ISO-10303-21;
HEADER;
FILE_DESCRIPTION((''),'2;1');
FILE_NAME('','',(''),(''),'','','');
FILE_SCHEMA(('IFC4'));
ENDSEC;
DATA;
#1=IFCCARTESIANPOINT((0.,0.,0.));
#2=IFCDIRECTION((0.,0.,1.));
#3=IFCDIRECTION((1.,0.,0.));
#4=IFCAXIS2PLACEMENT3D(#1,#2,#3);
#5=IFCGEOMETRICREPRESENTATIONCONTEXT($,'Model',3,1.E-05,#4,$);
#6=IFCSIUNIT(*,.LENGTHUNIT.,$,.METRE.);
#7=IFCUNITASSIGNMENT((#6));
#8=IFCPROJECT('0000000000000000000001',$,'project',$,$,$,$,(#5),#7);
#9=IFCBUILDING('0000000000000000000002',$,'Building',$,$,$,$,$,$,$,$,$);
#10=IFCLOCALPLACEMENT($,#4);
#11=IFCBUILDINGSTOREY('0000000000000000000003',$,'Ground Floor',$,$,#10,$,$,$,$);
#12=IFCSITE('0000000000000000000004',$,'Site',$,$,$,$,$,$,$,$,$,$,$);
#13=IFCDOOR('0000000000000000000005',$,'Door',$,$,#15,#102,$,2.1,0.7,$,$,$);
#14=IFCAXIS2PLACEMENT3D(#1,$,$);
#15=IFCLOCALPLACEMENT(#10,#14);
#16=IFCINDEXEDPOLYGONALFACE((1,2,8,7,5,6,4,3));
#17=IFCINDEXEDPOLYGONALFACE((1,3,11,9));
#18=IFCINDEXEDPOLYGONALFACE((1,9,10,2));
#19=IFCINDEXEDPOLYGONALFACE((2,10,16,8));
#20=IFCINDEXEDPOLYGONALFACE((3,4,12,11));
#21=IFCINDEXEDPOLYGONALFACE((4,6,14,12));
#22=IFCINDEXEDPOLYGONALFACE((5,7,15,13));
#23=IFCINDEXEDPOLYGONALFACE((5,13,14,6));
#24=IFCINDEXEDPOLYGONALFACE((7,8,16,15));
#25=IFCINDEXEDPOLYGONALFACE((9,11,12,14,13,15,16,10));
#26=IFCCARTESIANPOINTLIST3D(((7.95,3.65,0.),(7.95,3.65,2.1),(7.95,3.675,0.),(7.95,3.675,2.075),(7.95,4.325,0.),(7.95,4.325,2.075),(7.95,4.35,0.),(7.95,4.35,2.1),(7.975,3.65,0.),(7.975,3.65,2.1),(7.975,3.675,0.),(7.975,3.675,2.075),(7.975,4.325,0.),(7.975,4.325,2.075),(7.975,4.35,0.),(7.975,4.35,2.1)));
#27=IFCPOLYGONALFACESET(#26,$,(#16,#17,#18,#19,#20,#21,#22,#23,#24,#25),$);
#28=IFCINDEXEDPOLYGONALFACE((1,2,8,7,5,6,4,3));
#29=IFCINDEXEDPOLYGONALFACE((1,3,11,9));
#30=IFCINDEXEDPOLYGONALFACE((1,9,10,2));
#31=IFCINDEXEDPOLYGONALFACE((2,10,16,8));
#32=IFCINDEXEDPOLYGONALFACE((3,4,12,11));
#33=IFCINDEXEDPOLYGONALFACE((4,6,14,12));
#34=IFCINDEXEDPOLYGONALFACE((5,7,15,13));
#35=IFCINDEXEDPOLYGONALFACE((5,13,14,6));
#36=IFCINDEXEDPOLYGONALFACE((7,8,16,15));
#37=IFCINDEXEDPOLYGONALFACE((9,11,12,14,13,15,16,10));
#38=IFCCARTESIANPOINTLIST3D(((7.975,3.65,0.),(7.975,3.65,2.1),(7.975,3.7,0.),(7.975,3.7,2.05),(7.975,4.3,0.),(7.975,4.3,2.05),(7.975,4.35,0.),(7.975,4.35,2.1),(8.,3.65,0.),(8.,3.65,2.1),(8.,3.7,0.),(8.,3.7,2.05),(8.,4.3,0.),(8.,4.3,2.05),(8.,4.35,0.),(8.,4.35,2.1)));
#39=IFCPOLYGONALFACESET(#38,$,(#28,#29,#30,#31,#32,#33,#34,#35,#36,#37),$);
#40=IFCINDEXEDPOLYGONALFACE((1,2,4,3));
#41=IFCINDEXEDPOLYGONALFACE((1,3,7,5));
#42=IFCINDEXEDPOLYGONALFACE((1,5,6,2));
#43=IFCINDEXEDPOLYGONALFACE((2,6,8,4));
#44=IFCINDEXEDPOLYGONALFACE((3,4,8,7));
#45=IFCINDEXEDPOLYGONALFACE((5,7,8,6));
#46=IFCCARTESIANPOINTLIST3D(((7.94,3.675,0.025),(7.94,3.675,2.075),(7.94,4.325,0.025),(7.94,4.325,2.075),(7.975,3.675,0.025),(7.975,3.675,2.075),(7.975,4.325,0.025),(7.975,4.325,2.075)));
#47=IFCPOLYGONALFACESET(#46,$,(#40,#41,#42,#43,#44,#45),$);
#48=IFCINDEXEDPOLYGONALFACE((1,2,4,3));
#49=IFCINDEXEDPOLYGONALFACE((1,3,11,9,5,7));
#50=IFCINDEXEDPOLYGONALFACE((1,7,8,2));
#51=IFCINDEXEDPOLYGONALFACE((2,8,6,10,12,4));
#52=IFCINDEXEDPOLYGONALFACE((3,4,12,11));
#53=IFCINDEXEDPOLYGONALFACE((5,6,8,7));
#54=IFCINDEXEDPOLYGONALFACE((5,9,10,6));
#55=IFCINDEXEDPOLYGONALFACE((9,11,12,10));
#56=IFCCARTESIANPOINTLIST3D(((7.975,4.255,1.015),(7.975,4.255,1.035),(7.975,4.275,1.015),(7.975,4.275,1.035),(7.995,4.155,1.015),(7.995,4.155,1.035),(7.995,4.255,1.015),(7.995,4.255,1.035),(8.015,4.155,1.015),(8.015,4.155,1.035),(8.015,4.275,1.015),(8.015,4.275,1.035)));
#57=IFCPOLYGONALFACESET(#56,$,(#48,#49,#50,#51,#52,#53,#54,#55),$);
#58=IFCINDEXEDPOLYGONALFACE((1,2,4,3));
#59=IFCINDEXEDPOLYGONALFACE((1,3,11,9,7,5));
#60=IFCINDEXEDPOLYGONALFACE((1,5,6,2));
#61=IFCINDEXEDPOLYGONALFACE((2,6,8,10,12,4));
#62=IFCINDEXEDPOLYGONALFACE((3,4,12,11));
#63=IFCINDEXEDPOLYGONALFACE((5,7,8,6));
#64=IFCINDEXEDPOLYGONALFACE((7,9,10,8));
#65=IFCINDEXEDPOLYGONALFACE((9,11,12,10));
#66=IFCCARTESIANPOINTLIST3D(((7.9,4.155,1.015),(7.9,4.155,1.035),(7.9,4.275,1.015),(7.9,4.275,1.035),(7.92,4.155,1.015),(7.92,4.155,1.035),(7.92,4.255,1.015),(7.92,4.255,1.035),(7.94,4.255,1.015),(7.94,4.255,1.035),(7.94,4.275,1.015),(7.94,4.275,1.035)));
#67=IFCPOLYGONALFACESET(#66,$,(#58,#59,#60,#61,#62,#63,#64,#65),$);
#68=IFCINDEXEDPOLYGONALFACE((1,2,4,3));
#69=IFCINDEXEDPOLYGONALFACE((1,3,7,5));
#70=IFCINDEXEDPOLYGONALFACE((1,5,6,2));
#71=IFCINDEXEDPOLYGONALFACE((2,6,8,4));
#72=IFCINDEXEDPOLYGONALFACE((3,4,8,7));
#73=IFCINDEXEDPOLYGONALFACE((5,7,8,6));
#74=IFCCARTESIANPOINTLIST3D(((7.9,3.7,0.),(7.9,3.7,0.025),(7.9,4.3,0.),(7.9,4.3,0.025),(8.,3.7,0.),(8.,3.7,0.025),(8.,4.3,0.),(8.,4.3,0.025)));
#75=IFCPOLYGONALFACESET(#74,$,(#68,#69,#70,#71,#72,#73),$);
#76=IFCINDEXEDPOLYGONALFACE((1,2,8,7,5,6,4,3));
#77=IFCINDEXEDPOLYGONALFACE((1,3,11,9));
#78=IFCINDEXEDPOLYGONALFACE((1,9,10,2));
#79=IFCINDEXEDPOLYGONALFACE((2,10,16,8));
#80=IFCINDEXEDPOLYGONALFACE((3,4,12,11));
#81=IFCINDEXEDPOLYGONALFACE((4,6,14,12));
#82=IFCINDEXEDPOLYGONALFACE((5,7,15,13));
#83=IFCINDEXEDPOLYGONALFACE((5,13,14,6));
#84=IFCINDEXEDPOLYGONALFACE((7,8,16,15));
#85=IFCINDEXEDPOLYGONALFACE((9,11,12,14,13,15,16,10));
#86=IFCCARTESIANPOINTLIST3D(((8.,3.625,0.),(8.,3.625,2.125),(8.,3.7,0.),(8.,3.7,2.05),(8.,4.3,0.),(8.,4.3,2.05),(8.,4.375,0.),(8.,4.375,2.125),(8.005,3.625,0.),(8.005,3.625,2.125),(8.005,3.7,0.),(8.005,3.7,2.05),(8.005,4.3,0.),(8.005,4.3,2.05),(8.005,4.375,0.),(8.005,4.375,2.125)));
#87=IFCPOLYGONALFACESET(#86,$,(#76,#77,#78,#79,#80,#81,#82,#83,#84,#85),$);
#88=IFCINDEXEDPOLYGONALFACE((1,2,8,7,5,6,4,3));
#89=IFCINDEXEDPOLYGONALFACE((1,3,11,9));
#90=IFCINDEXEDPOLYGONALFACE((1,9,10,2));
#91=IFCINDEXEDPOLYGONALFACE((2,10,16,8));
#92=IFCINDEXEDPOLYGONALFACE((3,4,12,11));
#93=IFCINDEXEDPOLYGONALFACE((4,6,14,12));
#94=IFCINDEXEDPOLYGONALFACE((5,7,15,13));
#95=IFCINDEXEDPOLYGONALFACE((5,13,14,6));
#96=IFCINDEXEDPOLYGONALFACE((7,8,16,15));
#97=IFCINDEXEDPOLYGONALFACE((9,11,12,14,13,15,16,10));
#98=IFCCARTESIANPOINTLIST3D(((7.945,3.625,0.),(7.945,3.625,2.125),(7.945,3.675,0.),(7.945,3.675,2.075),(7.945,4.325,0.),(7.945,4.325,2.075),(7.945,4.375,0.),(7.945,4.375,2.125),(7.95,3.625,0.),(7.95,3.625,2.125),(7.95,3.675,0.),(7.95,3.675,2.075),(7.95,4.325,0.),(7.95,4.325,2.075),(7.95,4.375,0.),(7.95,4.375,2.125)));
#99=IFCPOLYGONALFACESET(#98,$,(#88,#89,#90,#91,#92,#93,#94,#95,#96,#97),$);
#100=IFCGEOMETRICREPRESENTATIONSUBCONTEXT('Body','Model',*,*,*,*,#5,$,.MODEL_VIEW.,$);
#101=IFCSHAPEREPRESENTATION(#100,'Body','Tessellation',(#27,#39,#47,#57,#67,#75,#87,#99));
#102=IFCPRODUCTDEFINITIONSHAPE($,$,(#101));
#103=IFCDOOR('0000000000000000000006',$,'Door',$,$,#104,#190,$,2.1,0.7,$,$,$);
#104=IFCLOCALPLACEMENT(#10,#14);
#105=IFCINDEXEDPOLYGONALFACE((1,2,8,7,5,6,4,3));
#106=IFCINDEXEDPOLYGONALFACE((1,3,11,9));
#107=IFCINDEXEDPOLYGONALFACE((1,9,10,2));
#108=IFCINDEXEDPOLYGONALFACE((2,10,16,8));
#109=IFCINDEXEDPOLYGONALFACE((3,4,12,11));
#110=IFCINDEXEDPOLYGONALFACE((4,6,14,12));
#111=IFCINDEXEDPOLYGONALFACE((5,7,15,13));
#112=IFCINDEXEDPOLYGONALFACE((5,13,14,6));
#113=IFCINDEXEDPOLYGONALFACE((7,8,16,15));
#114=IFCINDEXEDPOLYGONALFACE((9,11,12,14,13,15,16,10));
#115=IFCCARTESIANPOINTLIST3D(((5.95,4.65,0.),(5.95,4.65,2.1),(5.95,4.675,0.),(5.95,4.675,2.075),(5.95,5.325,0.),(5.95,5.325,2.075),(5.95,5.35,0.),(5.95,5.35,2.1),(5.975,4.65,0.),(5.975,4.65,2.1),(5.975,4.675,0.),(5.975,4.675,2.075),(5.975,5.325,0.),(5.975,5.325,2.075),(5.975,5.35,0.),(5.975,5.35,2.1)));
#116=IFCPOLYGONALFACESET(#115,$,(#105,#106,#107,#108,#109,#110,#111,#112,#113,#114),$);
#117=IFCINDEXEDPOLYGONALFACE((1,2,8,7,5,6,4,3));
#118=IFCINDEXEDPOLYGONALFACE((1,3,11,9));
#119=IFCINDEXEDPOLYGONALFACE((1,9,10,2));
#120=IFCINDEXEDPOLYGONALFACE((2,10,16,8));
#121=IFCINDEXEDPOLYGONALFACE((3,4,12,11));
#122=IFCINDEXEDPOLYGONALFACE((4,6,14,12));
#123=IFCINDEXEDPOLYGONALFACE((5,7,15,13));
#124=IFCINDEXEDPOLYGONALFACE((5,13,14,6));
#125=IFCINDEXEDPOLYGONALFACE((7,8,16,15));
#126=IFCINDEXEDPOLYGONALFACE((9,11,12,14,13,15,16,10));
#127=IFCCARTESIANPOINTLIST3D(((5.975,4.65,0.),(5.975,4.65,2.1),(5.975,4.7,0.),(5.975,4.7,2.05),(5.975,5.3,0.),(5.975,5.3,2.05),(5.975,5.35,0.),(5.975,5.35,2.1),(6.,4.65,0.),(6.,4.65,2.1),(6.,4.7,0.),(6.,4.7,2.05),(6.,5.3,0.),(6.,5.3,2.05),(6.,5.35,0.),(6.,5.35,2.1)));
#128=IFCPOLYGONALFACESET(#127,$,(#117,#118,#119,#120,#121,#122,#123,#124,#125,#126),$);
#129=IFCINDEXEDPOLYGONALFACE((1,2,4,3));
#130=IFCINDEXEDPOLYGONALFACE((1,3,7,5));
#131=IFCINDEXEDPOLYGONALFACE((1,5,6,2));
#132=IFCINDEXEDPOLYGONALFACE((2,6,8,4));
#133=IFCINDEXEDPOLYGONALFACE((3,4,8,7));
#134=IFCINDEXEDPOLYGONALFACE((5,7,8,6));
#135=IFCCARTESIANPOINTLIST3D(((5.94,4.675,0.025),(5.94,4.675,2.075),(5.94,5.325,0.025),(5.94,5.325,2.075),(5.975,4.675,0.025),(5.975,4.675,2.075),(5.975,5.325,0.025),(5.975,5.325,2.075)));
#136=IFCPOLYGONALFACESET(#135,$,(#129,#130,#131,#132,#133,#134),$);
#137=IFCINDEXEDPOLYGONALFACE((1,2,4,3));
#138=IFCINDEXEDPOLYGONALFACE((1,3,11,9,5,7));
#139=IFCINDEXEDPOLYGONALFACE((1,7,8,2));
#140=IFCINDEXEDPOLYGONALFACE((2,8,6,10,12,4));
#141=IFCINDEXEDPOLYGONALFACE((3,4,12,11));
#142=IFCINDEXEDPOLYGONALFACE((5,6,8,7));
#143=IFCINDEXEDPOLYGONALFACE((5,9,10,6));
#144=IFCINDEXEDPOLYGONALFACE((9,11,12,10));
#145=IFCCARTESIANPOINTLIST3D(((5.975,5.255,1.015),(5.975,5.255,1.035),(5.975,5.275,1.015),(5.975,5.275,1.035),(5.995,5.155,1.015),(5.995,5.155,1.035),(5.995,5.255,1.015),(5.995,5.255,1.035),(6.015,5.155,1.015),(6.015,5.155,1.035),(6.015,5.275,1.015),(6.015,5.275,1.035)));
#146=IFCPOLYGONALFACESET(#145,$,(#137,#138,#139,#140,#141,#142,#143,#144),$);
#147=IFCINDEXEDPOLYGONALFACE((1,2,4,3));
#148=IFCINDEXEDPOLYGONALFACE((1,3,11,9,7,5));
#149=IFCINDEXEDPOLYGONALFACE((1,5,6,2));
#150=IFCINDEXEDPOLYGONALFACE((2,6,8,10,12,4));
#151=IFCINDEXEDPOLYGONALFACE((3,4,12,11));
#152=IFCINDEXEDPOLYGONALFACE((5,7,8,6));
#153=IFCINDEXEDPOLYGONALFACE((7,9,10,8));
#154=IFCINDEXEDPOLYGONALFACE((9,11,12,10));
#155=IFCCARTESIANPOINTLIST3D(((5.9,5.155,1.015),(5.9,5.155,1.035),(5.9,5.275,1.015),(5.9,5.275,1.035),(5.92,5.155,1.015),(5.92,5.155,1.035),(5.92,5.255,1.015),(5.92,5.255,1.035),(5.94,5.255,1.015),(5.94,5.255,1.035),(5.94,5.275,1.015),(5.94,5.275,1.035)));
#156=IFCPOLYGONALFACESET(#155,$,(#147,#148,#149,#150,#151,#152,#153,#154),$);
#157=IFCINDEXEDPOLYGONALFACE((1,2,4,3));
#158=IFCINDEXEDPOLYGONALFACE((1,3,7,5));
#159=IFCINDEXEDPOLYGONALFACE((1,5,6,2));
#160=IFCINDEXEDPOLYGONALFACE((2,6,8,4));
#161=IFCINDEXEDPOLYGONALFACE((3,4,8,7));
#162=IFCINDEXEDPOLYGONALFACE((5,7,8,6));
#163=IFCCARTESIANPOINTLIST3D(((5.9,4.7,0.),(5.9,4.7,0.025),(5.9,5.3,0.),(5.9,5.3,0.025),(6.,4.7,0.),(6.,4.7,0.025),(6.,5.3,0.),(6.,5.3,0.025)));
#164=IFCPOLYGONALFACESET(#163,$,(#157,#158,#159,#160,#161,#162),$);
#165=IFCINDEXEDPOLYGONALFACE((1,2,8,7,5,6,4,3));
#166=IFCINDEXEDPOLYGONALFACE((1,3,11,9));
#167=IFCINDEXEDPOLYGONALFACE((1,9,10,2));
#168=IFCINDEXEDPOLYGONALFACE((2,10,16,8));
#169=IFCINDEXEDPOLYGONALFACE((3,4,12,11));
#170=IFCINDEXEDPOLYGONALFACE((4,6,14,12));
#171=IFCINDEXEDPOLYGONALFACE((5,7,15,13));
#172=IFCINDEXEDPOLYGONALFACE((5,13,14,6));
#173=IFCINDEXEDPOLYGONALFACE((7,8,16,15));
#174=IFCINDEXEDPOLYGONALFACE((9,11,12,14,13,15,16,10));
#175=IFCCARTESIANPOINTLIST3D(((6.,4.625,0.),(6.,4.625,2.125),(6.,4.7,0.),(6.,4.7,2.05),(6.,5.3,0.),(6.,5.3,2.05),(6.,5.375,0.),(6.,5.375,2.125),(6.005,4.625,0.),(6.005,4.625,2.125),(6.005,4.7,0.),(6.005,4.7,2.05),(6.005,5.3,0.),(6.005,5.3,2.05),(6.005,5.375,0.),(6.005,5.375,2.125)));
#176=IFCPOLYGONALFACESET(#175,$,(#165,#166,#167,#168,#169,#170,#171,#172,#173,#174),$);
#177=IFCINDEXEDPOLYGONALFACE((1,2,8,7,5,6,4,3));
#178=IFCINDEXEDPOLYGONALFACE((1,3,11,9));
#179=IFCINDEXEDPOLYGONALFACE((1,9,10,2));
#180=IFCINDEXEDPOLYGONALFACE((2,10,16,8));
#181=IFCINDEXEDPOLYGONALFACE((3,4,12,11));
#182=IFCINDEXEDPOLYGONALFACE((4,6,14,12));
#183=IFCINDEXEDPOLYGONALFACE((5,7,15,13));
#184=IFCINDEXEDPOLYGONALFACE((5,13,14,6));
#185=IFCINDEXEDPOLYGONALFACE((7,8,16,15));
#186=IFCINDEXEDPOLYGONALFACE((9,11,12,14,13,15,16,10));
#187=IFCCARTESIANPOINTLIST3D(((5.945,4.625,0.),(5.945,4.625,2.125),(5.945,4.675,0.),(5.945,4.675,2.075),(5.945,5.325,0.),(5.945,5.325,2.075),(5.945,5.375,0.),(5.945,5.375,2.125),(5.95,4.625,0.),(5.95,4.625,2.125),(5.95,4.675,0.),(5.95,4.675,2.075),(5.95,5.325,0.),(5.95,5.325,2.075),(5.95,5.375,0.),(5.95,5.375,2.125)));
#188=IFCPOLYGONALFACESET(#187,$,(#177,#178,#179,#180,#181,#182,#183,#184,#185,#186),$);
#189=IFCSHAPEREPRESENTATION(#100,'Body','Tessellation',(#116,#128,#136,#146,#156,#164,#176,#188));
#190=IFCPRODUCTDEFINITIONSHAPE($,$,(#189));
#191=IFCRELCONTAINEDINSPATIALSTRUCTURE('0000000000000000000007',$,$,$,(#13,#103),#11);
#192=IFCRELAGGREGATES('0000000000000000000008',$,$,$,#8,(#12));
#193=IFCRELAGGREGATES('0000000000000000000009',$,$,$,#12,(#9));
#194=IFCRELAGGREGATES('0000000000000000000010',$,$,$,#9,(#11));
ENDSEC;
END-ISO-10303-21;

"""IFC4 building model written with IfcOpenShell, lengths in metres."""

from ifc_helpers import new_model, si_unit, frame, origin_with_axes, place, context, subcontext, project, spatial, line, indexed_curve, outline, extrude, element, save


model = new_model("IFC4")

# Units and contexts
model_context = context("Model", 3, precision=1e-05, world=origin_with_axes())
body_context = subcontext(model_context, "Body", "Model", "MODEL_VIEW")
ifc_project = project(units=[si_unit("LENGTHUNIT", "METRE")], contexts=[model_context])

# Site, building, storey
site = spatial("IfcSite", under=ifc_project, Name="Site")
building = spatial("IfcBuilding", under=site, Name="Building")
storey_placement = place(None, origin_with_axes())
storey = spatial("IfcBuildingStorey", under=building, at=storey_placement, Name="Ground Floor")

# Doors
door_1_placement = place(storey_placement, frame((8.0, 3.65, 0.0), z_axis=(0.0, 0.0, 1.0), x_axis=(0.0, 1.0, 0.0)))
element("IfcDoor", 1, at=door_1_placement, inside=storey, Name="Door", OverallHeight=2.1, OverallWidth=0.7, context=body_context, shape_type="SweptSolid", body=[
    extrude(outline(indexed_curve([(0.0, 0.0), (0.0, 2.1), (0.7, 2.1), (0.7, 0.0), (0.675, 0.0), (0.675, 2.075), (0.025, 2.075), (0.025, 0.0)], segments=[line(1, 2, 3, 4, 5, 6, 7, 8, 1)])), frame((0.0, 0.025, 0.0), z_axis=(0.0, -1.0, 0.0), x_axis=(1.0, 0.0, 0.0)), (0.0, 0.0, -1.0), 0.025),
    extrude(outline(indexed_curve([(0.0, 0.0), (0.0, 2.1), (0.7, 2.1), (0.7, 0.0), (0.65, 0.0), (0.65, 2.05), (0.05, 2.05), (0.05, 0.0)], segments=[line(1, 2, 3, 4, 5, 6, 7, 8, 1)])), frame((0.0, 0.0, 0.0), z_axis=(0.0, -1.0, 0.0), x_axis=(1.0, 0.0, 0.0)), (0.0, 0.0, -1.0), 0.025),
    extrude(outline(indexed_curve([(0.0, 0.0), (0.65, 0.0), (0.65, 0.035), (0.0, 0.035)], segments=[line(1, 2, 3, 4, 1)])), frame((0.025, 0.025, 0.025), z_axis=(0.0, 0.0, 1.0), x_axis=(1.0, 0.0, 0.0)), (0.0, 0.0, 1.0), 2.05),
    extrude(outline(indexed_curve([(0.0, 0.0), (0.0, -0.04), (-0.12, -0.04), (-0.12, -0.02), (-0.02, -0.02), (-0.02, 0.0)], segments=[line(1, 2, 3, 4, 5, 6, 1)])), frame((0.625, 0.025, 1.015), z_axis=(0.0, 0.0, 1.0), x_axis=(1.0, 0.0, 0.0)), (0.0, 0.0, 1.0), 0.02),
    extrude(outline(indexed_curve([(0.0, 0.0), (0.0, 0.04), (-0.12, 0.04), (-0.12, 0.02), (-0.02, 0.02), (-0.02, 0.0)], segments=[line(1, 2, 3, 4, 5, 6, 1)])), frame((0.625, 0.06, 1.015), z_axis=(0.0, 0.0, 1.0), x_axis=(1.0, 0.0, 0.0)), (0.0, 0.0, 1.0), 0.02),
    extrude(outline(indexed_curve([(0.0, 0.0), (0.6, 0.0), (0.6, 0.1), (0.0, 0.1)], segments=[line(1, 2, 3, 4, 1)])), frame((0.05, 0.0, 0.0), z_axis=(0.0, 0.0, 1.0), x_axis=(1.0, 0.0, 0.0)), (0.0, 0.0, 1.0), 0.025),
    extrude(outline(indexed_curve([(0.0, 0.0), (0.0, 2.125), (0.75, 2.125), (0.75, 0.0), (0.675, 0.0), (0.675, 2.05), (0.075, 2.05), (0.075, 0.0)], segments=[line(1, 2, 3, 4, 5, 6, 7, 8, 1)])), frame((-0.025, -0.005, 0.0), z_axis=(0.0, -1.0, 0.0), x_axis=(1.0, 0.0, 0.0)), (0.0, 0.0, -1.0), 0.005),
    extrude(outline(indexed_curve([(0.0, 0.0), (0.0, 2.125), (0.75, 2.125), (0.75, 0.0), (0.7, 0.0), (0.7, 2.075), (0.05, 2.075), (0.05, 0.0)], segments=[line(1, 2, 3, 4, 5, 6, 7, 8, 1)])), frame((-0.025, 0.05, 0.0), z_axis=(0.0, -1.0, 0.0), x_axis=(1.0, 0.0, 0.0)), (0.0, 0.0, -1.0), 0.005),
])
door_2_placement = place(storey_placement, frame((6.0, 4.65, 0.0), z_axis=(0.0, 0.0, 1.0), x_axis=(0.0, 1.0, 0.0)))
element("IfcDoor", 2, at=door_2_placement, inside=storey, Name="Door", OverallHeight=2.1, OverallWidth=0.7, context=body_context, shape_type="SweptSolid", body=[
    extrude(outline(indexed_curve([(0.0, 0.0), (0.0, 2.1), (0.7, 2.1), (0.7, 0.0), (0.675, 0.0), (0.675, 2.075), (0.025, 2.075), (0.025, 0.0)], segments=[line(1, 2, 3, 4, 5, 6, 7, 8, 1)])), frame((0.0, 0.025, 0.0), z_axis=(0.0, -1.0, 0.0), x_axis=(1.0, 0.0, 0.0)), (0.0, 0.0, -1.0), 0.025),
    extrude(outline(indexed_curve([(0.0, 0.0), (0.0, 2.1), (0.7, 2.1), (0.7, 0.0), (0.65, 0.0), (0.65, 2.05), (0.05, 2.05), (0.05, 0.0)], segments=[line(1, 2, 3, 4, 5, 6, 7, 8, 1)])), frame((0.0, 0.0, 0.0), z_axis=(0.0, -1.0, 0.0), x_axis=(1.0, 0.0, 0.0)), (0.0, 0.0, -1.0), 0.025),
    extrude(outline(indexed_curve([(0.0, 0.0), (0.65, 0.0), (0.65, 0.035), (0.0, 0.035)], segments=[line(1, 2, 3, 4, 1)])), frame((0.025, 0.025, 0.025), z_axis=(0.0, 0.0, 1.0), x_axis=(1.0, 0.0, 0.0)), (0.0, 0.0, 1.0), 2.05),
    extrude(outline(indexed_curve([(0.0, 0.0), (0.0, -0.04), (-0.12, -0.04), (-0.12, -0.02), (-0.02, -0.02), (-0.02, 0.0)], segments=[line(1, 2, 3, 4, 5, 6, 1)])), frame((0.625, 0.025, 1.015), z_axis=(0.0, 0.0, 1.0), x_axis=(1.0, 0.0, 0.0)), (0.0, 0.0, 1.0), 0.02),
    extrude(outline(indexed_curve([(0.0, 0.0), (0.0, 0.04), (-0.12, 0.04), (-0.12, 0.02), (-0.02, 0.02), (-0.02, 0.0)], segments=[line(1, 2, 3, 4, 5, 6, 1)])), frame((0.625, 0.06, 1.015), z_axis=(0.0, 0.0, 1.0), x_axis=(1.0, 0.0, 0.0)), (0.0, 0.0, 1.0), 0.02),
    extrude(outline(indexed_curve([(0.0, 0.0), (0.6, 0.0), (0.6, 0.1), (0.0, 0.1)], segments=[line(1, 2, 3, 4, 1)])), frame((0.05, 0.0, 0.0), z_axis=(0.0, 0.0, 1.0), x_axis=(1.0, 0.0, 0.0)), (0.0, 0.0, 1.0), 0.025),
    extrude(outline(indexed_curve([(0.0, 0.0), (0.0, 2.125), (0.75, 2.125), (0.75, 0.0), (0.675, 0.0), (0.675, 2.05), (0.075, 2.05), (0.075, 0.0)], segments=[line(1, 2, 3, 4, 5, 6, 7, 8, 1)])), frame((-0.025, -0.005, 0.0), z_axis=(0.0, -1.0, 0.0), x_axis=(1.0, 0.0, 0.0)), (0.0, 0.0, -1.0), 0.005),
    extrude(outline(indexed_curve([(0.0, 0.0), (0.0, 2.125), (0.75, 2.125), (0.75, 0.0), (0.7, 0.0), (0.7, 2.075), (0.05, 2.075), (0.05, 0.0)], segments=[line(1, 2, 3, 4, 5, 6, 7, 8, 1)])), frame((-0.025, 0.05, 0.0), z_axis=(0.0, -1.0, 0.0), x_axis=(1.0, 0.0, 0.0)), (0.0, 0.0, -1.0), 0.005),
])

save(model, "model.ifc")
